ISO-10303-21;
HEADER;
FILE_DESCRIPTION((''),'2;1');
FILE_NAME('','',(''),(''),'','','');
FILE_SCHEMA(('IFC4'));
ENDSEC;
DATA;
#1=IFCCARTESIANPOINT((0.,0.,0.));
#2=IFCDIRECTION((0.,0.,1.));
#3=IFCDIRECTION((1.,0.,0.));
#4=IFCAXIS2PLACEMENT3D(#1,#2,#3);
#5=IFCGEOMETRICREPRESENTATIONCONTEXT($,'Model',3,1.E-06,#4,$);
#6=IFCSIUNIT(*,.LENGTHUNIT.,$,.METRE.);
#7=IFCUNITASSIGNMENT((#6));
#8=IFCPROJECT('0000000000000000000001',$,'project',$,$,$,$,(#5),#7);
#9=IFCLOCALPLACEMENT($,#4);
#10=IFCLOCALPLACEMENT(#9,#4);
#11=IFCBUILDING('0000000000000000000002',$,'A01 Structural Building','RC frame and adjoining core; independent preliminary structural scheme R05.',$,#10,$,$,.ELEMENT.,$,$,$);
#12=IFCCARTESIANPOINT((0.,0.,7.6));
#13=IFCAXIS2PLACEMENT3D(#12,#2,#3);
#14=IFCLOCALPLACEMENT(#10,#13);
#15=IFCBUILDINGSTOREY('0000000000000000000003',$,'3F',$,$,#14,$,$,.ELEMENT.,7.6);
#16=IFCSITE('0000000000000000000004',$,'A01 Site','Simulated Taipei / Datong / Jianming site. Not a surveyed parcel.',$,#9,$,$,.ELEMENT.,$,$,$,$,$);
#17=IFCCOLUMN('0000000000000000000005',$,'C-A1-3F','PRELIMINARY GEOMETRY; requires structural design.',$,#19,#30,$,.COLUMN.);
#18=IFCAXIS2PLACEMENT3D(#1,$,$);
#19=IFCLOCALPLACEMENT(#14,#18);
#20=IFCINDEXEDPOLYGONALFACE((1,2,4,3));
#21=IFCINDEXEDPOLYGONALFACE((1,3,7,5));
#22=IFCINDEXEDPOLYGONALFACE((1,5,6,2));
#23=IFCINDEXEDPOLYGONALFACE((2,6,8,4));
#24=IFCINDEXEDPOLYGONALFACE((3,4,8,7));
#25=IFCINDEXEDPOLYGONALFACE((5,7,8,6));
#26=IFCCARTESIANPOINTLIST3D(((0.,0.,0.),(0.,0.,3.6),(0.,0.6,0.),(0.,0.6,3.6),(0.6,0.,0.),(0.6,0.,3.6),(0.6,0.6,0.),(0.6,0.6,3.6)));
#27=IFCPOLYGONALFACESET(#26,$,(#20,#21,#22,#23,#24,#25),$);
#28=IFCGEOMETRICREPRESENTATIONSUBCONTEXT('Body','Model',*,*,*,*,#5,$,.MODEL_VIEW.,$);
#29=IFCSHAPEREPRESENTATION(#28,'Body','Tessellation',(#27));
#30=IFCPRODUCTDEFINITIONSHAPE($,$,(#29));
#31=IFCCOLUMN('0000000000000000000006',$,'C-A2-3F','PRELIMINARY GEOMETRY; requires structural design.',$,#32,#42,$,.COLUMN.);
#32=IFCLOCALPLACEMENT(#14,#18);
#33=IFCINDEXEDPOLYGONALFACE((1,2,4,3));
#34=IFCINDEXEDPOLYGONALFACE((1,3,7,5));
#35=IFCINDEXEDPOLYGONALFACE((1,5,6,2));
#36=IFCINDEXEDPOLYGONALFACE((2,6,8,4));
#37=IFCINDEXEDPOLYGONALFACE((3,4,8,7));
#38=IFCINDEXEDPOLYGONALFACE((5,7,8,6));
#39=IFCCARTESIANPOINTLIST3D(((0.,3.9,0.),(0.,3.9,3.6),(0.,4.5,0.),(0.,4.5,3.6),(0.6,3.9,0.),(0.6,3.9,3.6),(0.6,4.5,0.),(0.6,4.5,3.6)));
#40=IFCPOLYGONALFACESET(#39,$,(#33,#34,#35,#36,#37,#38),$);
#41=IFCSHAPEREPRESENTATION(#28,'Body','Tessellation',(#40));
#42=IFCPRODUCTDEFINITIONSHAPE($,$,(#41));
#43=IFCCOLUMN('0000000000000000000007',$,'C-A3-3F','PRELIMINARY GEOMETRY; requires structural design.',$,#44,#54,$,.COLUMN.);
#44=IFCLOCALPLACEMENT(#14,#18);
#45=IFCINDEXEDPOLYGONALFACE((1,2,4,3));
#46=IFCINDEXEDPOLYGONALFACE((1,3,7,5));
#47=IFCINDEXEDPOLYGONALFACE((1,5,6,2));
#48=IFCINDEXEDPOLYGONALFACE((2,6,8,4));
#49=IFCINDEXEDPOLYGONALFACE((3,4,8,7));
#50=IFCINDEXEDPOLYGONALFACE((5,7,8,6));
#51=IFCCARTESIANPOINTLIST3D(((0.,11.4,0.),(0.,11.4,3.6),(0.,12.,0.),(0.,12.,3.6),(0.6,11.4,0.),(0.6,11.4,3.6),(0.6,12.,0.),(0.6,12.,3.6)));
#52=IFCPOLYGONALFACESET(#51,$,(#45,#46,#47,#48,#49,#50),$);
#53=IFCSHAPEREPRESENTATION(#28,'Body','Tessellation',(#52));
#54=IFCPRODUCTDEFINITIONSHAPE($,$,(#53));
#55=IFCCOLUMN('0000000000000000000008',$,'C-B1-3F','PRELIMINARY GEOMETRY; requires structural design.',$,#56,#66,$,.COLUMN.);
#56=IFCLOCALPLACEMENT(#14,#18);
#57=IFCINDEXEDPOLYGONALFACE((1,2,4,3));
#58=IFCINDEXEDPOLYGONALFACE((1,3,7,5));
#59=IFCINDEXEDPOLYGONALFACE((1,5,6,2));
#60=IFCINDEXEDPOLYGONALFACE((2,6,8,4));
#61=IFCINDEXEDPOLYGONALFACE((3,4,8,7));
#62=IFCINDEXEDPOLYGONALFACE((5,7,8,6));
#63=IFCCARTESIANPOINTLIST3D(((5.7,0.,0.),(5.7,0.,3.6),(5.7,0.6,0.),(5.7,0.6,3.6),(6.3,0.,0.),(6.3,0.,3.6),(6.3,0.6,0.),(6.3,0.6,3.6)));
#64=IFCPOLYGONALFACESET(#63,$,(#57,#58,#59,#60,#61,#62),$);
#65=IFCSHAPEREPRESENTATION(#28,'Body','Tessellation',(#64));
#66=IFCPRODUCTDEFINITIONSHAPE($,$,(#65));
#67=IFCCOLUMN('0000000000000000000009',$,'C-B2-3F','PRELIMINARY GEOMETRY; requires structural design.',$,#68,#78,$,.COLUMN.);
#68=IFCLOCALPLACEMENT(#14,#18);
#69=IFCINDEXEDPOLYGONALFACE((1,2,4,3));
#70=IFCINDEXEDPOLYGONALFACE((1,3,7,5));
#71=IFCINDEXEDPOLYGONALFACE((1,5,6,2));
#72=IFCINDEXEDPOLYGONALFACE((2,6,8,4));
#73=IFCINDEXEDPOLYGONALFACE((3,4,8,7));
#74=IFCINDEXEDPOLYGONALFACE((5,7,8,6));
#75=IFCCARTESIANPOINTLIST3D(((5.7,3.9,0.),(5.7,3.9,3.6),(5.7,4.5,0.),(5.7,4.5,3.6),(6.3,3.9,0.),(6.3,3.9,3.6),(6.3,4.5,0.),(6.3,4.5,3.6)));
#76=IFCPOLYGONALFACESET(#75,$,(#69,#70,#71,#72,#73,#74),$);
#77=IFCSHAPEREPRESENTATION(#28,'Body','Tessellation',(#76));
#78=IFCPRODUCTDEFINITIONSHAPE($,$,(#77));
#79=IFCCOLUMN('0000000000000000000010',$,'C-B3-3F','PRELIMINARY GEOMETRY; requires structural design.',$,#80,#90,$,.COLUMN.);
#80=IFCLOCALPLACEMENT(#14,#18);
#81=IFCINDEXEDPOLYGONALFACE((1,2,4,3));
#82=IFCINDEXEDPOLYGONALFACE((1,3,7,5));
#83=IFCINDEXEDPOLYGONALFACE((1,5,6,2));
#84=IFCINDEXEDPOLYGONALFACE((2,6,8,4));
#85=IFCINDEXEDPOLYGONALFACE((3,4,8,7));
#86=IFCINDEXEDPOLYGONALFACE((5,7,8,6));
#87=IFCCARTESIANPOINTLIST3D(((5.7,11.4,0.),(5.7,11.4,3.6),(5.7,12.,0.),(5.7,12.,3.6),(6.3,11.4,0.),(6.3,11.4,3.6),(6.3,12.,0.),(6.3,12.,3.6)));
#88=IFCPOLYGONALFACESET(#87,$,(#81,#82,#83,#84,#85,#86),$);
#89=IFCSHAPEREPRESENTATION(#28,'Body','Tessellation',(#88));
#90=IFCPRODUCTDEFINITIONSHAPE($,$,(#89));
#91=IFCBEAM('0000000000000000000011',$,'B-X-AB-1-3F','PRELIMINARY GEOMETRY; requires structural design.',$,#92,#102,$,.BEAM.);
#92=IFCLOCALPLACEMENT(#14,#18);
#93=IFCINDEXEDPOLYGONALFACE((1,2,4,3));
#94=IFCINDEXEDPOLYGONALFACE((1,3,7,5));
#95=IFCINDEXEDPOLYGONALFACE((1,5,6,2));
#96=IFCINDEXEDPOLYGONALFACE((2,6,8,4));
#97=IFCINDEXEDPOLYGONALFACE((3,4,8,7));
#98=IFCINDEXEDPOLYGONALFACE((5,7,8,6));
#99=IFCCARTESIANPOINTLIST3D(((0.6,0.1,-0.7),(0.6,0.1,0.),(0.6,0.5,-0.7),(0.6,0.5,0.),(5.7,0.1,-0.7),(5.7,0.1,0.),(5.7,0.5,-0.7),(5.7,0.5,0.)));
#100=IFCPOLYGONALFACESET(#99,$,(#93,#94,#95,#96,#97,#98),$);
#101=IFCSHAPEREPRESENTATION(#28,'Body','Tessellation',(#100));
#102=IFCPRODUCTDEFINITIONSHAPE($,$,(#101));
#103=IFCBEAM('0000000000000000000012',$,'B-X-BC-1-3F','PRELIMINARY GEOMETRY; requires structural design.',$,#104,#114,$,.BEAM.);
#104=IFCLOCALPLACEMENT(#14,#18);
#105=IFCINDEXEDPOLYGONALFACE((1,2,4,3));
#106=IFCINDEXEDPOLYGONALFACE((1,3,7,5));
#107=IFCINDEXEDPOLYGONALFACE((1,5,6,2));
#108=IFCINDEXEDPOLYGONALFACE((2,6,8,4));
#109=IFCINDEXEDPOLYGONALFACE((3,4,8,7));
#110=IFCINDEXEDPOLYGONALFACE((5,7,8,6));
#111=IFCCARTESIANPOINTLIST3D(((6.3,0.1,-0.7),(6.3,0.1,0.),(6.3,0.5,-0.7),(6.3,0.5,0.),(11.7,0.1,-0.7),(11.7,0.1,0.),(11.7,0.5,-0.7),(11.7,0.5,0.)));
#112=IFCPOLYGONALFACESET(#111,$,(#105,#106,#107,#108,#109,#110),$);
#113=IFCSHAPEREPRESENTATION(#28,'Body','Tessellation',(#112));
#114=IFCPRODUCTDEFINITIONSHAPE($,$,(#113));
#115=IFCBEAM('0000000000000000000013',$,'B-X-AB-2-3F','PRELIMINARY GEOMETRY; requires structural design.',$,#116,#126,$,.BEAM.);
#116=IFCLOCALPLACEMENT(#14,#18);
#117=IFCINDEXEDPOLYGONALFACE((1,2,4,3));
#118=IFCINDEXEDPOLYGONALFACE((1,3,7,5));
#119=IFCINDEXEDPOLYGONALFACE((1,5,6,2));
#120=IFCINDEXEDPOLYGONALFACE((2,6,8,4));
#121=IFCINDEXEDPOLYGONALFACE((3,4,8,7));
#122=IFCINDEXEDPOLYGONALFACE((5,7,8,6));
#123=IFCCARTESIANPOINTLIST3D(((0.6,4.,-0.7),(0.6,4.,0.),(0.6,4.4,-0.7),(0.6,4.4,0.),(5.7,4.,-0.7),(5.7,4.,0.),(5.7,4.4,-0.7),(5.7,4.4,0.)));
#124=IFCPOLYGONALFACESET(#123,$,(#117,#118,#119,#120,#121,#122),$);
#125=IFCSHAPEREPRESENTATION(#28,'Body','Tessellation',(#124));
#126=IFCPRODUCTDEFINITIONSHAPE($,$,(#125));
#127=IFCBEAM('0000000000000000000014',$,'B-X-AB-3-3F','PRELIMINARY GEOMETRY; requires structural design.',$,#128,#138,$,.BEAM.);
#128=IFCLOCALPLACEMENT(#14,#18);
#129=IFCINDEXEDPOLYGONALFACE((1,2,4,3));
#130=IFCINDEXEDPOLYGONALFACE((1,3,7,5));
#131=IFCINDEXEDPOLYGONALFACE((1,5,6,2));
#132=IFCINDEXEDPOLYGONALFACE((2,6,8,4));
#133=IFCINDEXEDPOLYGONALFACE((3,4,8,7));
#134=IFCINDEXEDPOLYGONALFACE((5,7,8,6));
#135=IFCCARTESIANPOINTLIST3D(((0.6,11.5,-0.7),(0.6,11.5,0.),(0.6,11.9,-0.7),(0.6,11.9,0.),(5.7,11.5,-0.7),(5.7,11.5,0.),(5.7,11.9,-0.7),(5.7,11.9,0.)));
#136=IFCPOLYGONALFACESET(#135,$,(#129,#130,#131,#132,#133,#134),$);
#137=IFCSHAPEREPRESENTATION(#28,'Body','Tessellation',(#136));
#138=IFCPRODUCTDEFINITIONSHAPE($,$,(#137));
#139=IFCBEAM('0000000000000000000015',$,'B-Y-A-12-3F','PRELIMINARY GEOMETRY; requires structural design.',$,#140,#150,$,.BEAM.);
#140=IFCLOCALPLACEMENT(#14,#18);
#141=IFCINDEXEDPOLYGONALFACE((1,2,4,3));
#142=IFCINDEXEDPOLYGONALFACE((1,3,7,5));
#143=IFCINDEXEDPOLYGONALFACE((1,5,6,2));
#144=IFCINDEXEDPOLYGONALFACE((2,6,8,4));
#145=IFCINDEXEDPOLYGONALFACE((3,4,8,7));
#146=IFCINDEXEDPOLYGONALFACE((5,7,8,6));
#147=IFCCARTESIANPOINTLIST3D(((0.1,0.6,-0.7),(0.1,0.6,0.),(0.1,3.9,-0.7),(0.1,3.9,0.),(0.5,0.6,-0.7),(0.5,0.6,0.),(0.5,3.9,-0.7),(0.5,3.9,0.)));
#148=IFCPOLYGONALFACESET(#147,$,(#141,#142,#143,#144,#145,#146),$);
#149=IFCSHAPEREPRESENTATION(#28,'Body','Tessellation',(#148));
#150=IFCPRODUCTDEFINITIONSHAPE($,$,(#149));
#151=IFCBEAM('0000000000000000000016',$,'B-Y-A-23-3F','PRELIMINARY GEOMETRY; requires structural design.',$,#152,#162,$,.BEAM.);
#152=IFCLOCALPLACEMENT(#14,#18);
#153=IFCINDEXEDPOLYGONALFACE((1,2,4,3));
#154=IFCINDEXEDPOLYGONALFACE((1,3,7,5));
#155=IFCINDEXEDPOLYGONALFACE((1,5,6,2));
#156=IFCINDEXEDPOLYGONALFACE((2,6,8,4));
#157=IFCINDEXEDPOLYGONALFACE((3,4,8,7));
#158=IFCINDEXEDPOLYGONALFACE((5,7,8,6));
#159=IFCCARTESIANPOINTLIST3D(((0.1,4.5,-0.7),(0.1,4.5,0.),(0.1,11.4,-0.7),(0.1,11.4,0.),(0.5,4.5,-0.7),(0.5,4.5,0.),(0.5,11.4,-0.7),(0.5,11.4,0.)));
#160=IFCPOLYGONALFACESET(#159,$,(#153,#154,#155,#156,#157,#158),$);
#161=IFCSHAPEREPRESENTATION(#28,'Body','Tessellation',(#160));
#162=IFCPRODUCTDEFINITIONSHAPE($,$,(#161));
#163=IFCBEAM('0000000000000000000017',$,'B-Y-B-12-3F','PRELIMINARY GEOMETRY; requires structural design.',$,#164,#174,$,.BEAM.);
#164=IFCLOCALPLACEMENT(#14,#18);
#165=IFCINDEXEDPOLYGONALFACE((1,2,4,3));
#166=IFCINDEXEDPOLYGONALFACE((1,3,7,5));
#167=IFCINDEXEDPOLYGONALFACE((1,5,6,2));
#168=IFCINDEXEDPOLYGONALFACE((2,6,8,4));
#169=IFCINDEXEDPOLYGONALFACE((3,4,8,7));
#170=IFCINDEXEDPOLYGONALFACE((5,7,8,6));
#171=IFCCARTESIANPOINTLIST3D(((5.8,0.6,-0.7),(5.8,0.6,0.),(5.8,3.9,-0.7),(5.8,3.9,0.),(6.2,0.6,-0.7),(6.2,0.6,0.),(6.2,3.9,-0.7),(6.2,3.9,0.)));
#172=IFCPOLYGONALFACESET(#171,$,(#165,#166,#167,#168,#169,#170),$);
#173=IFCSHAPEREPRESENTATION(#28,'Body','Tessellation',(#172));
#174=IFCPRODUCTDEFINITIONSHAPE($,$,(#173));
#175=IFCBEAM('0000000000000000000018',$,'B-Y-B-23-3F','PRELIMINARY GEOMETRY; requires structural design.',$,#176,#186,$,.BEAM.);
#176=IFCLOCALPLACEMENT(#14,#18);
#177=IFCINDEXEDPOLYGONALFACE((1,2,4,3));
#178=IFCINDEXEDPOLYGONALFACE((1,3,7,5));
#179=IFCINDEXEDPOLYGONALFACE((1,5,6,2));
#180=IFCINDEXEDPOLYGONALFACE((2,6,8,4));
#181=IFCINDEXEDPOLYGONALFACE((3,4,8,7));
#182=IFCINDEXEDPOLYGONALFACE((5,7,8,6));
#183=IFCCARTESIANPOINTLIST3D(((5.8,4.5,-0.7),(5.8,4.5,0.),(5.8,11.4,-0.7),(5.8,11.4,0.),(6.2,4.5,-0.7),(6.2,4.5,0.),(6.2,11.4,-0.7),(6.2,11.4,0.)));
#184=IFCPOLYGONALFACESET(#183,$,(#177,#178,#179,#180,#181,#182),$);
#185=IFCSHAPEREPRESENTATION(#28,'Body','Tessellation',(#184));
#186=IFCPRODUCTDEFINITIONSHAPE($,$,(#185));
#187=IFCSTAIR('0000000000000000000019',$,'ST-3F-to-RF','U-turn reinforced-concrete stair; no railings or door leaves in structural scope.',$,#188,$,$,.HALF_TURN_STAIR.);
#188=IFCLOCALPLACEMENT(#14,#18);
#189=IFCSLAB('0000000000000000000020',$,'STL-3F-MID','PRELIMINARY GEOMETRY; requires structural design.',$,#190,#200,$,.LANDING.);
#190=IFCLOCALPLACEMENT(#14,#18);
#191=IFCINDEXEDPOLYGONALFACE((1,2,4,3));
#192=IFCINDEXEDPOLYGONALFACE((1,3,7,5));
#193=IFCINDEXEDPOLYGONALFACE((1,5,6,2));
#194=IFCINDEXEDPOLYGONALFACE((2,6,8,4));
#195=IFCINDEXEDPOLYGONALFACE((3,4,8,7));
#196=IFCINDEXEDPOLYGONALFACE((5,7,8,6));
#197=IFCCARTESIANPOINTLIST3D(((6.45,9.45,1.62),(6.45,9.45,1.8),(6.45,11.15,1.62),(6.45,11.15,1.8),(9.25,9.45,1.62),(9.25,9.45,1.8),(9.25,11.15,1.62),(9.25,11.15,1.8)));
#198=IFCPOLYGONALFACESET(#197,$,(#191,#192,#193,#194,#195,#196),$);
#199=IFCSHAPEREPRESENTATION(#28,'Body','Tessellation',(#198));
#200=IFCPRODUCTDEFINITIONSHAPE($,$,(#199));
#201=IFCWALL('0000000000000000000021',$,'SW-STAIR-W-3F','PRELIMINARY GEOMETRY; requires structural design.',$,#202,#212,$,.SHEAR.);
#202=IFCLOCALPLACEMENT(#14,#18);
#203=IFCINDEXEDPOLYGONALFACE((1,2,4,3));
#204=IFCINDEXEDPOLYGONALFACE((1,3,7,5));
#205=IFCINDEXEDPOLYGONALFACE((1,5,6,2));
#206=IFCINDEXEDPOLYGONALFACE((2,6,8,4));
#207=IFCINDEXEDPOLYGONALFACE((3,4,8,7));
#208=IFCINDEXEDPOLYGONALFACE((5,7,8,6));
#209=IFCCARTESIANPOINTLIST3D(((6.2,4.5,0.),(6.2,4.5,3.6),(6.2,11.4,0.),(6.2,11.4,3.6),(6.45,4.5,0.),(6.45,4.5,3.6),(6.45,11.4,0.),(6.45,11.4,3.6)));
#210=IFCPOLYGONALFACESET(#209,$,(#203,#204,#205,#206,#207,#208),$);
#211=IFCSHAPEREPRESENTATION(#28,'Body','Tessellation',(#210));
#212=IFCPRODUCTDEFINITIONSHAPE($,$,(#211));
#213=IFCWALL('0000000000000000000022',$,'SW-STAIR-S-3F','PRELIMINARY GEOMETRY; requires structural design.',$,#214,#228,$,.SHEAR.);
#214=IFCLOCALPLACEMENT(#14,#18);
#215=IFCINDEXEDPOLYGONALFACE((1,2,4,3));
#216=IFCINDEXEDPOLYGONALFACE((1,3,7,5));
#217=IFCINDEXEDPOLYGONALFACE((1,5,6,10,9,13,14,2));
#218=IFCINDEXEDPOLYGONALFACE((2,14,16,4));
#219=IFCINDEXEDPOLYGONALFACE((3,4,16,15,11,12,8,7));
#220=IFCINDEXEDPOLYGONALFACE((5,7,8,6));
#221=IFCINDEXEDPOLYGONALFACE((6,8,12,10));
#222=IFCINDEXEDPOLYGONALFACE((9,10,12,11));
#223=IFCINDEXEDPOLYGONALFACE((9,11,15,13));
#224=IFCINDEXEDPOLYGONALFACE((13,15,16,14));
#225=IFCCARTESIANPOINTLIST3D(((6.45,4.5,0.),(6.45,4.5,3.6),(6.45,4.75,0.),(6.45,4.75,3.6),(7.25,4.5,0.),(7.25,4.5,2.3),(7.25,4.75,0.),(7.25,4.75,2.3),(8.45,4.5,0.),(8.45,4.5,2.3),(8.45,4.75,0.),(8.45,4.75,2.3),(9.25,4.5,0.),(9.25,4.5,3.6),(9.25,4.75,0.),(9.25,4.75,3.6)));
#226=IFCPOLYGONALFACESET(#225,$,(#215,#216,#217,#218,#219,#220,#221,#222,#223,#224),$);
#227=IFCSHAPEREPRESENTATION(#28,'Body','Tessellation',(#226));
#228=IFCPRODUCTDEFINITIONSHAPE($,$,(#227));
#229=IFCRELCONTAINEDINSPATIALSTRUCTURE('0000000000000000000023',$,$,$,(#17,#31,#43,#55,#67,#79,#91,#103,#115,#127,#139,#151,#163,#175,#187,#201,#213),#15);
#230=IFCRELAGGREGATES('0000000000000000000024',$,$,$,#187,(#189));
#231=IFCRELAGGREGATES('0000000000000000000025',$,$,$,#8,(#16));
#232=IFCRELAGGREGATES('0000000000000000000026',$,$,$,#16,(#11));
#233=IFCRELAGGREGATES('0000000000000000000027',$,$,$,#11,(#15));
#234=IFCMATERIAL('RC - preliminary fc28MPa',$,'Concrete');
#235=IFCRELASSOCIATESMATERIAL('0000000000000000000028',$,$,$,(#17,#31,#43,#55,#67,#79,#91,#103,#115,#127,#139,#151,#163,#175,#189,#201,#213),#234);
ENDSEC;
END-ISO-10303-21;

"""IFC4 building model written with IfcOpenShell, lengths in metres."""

from ifc_helpers import new_model, si_unit, frame, origin_with_axes, place, context, subcontext, project, spatial, rectangle, extrude, material, element, aggregate, save


model = new_model("IFC4")

# Units and contexts
model_context = context("Model", 3, precision=1e-06, world=origin_with_axes())
body_context = subcontext(model_context, "Body", "Model", "MODEL_VIEW")
ifc_project = project(units=[si_unit("LENGTHUNIT", "METRE")], contexts=[model_context])

# Site, building, storey
site_placement = place(None, origin_with_axes())
site = spatial("IfcSite", under=ifc_project, at=site_placement, Name="A01 Site", Description="Simulated Taipei / Datong / Jianming site. Not a surveyed parcel.", CompositionType="ELEMENT")
building_placement = place(site_placement, origin_with_axes())
building = spatial("IfcBuilding", under=site, at=building_placement, Name="A01 Structural Building", Description="RC frame and adjoining core; independent preliminary structural scheme R05.", CompositionType="ELEMENT")
storey_placement = place(building_placement, frame((0.0, 0.0, 7.6), z_axis=(0.0, 0.0, 1.0), x_axis=(1.0, 0.0, 0.0)))
storey = spatial("IfcBuildingStorey", under=building, at=storey_placement, Name="3F", CompositionType="ELEMENT", Elevation=7.6)

# Columns
ifc_material = material(Name="RC - preliminary fc28MPa", Category="Concrete")
for number, where, z_axis, x_axis, name in (
    (1, (0.3, 0.3, 0.0), (0.0, 0.0, 1.0), (1.0, 0.0, 0.0), "C-A1-3F"),
    (2, (0.3, 4.2, 0.0), (0.0, 0.0, 1.0), (1.0, 0.0, 0.0), "C-A2-3F"),
    (3, (0.3, 11.7, 0.0), (0.0, 0.0, 1.0), (1.0, 0.0, 0.0), "C-A3-3F"),
    (4, (6.0, 0.3, 0.0), (0.0, 0.0, 1.0), (1.0, 0.0, 0.0), "C-B1-3F"),
    (5, (6.0, 4.2, 0.0), (0.0, 0.0, 1.0), (1.0, 0.0, 0.0), "C-B2-3F"),
    (6, (6.0, 11.7, 0.0), (0.0, 0.0, 1.0), (1.0, 0.0, 0.0), "C-B3-3F"),
):
    element("IfcColumn", number, at=place(storey_placement, frame(where, z_axis=z_axis, x_axis=x_axis)), inside=storey, material=ifc_material, Name=name, Description="PRELIMINARY GEOMETRY; requires structural design.", PredefinedType="COLUMN", context=body_context, shape_type="SweptSolid", body=[
        extrude(rectangle(XDim=0.6, YDim=0.6), origin_with_axes(), (0.0, 0.0, 1.0), 3.6),
    ])

# Beams
beam_1_placement = place(storey_placement, frame((3.15, 0.3, -0.7), z_axis=(0.0, 0.0, 1.0), x_axis=(1.0, 0.0, 0.0)))
element("IfcBeam", 7, at=beam_1_placement, inside=storey, material=ifc_material, Name="B-X-AB-1-3F", Description="PRELIMINARY GEOMETRY; requires structural design.", PredefinedType="BEAM", context=body_context, shape_type="SweptSolid", body=[
    extrude(rectangle(XDim=5.1, YDim=0.4), origin_with_axes(), (0.0, 0.0, 1.0), 0.7),
])
beam_2_placement = place(storey_placement, frame((9.0, 0.3, -0.7), z_axis=(0.0, 0.0, 1.0), x_axis=(1.0, 0.0, 0.0)))
element("IfcBeam", 8, at=beam_2_placement, inside=storey, material=ifc_material, Name="B-X-BC-1-3F", Description="PRELIMINARY GEOMETRY; requires structural design.", PredefinedType="BEAM", context=body_context, shape_type="SweptSolid", body=[
    extrude(rectangle(XDim=5.4, YDim=0.4), origin_with_axes(), (0.0, 0.0, 1.0), 0.7),
])
for number, where, z_axis, x_axis, name in (
    (9, (3.15, 4.2, -0.7), (0.0, 0.0, 1.0), (1.0, 0.0, 0.0), "B-X-AB-2-3F"),
    (10, (3.15, 11.7, -0.7), (0.0, 0.0, 1.0), (1.0, 0.0, 0.0), "B-X-AB-3-3F"),
):
    element("IfcBeam", number, at=place(storey_placement, frame(where, z_axis=z_axis, x_axis=x_axis)), inside=storey, material=ifc_material, Name=name, Description="PRELIMINARY GEOMETRY; requires structural design.", PredefinedType="BEAM", context=body_context, shape_type="SweptSolid", body=[
        extrude(rectangle(XDim=5.1, YDim=0.4), origin_with_axes(), (0.0, 0.0, 1.0), 0.7),
    ])
beam_3_placement = place(storey_placement, frame((0.3, 2.25, -0.7), z_axis=(0.0, 0.0, 1.0), x_axis=(1.0, 0.0, 0.0)))
element("IfcBeam", 11, at=beam_3_placement, inside=storey, material=ifc_material, Name="B-Y-A-12-3F", Description="PRELIMINARY GEOMETRY; requires structural design.", PredefinedType="BEAM", context=body_context, shape_type="SweptSolid", body=[
    extrude(rectangle(XDim=0.4, YDim=3.3), origin_with_axes(), (0.0, 0.0, 1.0), 0.7),
])
beam_4_placement = place(storey_placement, frame((0.3, 7.95, -0.7), z_axis=(0.0, 0.0, 1.0), x_axis=(1.0, 0.0, 0.0)))
element("IfcBeam", 12, at=beam_4_placement, inside=storey, material=ifc_material, Name="B-Y-A-23-3F", Description="PRELIMINARY GEOMETRY; requires structural design.", PredefinedType="BEAM", context=body_context, shape_type="SweptSolid", body=[
    extrude(rectangle(XDim=0.4, YDim=6.9), origin_with_axes(), (0.0, 0.0, 1.0), 0.7),
])
beam_5_placement = place(storey_placement, frame((6.0, 2.25, -0.7), z_axis=(0.0, 0.0, 1.0), x_axis=(1.0, 0.0, 0.0)))
element("IfcBeam", 13, at=beam_5_placement, inside=storey, material=ifc_material, Name="B-Y-B-12-3F", Description="PRELIMINARY GEOMETRY; requires structural design.", PredefinedType="BEAM", context=body_context, shape_type="SweptSolid", body=[
    extrude(rectangle(XDim=0.4, YDim=3.3), origin_with_axes(), (0.0, 0.0, 1.0), 0.7),
])
beam_6_placement = place(storey_placement, frame((6.0, 7.95, -0.7), z_axis=(0.0, 0.0, 1.0), x_axis=(1.0, 0.0, 0.0)))
element("IfcBeam", 14, at=beam_6_placement, inside=storey, material=ifc_material, Name="B-Y-B-23-3F", Description="PRELIMINARY GEOMETRY; requires structural design.", PredefinedType="BEAM", context=body_context, shape_type="SweptSolid", body=[
    extrude(rectangle(XDim=0.4, YDim=6.9), origin_with_axes(), (0.0, 0.0, 1.0), 0.7),
])

# Stair, slab
stair_placement = place(storey_placement, origin_with_axes())
stair = element("IfcStair", 15, at=stair_placement, inside=storey, Name="ST-3F-to-RF", Description="U-turn reinforced-concrete stair; no railings or door leaves in structural scope.", PredefinedType="HALF_TURN_STAIR")
slab_placement = place(storey_placement, frame((7.85, 10.3, 1.62), z_axis=(0.0, 0.0, 1.0), x_axis=(1.0, 0.0, 0.0)))
slab = element("IfcSlab", 16, at=slab_placement, material=ifc_material, Name="STL-3F-MID", Description="PRELIMINARY GEOMETRY; requires structural design.", PredefinedType="LANDING", context=body_context, shape_type="SweptSolid", body=[
    extrude(rectangle(XDim=2.8, YDim=1.7), origin_with_axes(), (0.0, 0.0, 1.0), 0.18),
])

# Wall
wall_1_placement = place(storey_placement, frame((6.325, 7.95, 0.0), z_axis=(0.0, 0.0, 1.0), x_axis=(1.0, 0.0, 0.0)))
element("IfcWall", 17, at=wall_1_placement, inside=storey, material=ifc_material, Name="SW-STAIR-W-3F", Description="PRELIMINARY GEOMETRY; requires structural design.", PredefinedType="SHEAR", context=body_context, shape_type="SweptSolid", body=[
    extrude(rectangle(XDim=0.25, YDim=6.9), origin_with_axes(), (0.0, 0.0, 1.0), 3.6),
])

# Wall, opening
wall_2_placement = place(storey_placement, frame((7.85, 4.625, 0.0), z_axis=(0.0, 0.0, 1.0), x_axis=(1.0, 0.0, 0.0)))
wall_2 = element("IfcWall", 18, at=wall_2_placement, inside=storey, material=ifc_material, Name="SW-STAIR-S-3F", Description="PRELIMINARY GEOMETRY; requires structural design.", PredefinedType="SHEAR", context=body_context, shape_type="SweptSolid", body=[
    extrude(rectangle(XDim=2.8, YDim=0.25), origin_with_axes(), (0.0, 0.0, 1.0), 3.6),
])
opening_placement = place(storey_placement, frame((7.85, 4.625, 0.0), z_axis=(0.0, 0.0, 1.0), x_axis=(1.0, 0.0, 0.0)))
element("IfcOpeningElement", 19, at=opening_placement, cuts=wall_2, PredefinedType="OPENING", context=body_context, shape_type="SweptSolid", body=[
    extrude(rectangle(XDim=1.2, YDim=0.45), origin_with_axes(), (0.0, 0.0, 1.0), 2.3),
])

aggregate(stair, [slab])

save(model, "model.ifc")
